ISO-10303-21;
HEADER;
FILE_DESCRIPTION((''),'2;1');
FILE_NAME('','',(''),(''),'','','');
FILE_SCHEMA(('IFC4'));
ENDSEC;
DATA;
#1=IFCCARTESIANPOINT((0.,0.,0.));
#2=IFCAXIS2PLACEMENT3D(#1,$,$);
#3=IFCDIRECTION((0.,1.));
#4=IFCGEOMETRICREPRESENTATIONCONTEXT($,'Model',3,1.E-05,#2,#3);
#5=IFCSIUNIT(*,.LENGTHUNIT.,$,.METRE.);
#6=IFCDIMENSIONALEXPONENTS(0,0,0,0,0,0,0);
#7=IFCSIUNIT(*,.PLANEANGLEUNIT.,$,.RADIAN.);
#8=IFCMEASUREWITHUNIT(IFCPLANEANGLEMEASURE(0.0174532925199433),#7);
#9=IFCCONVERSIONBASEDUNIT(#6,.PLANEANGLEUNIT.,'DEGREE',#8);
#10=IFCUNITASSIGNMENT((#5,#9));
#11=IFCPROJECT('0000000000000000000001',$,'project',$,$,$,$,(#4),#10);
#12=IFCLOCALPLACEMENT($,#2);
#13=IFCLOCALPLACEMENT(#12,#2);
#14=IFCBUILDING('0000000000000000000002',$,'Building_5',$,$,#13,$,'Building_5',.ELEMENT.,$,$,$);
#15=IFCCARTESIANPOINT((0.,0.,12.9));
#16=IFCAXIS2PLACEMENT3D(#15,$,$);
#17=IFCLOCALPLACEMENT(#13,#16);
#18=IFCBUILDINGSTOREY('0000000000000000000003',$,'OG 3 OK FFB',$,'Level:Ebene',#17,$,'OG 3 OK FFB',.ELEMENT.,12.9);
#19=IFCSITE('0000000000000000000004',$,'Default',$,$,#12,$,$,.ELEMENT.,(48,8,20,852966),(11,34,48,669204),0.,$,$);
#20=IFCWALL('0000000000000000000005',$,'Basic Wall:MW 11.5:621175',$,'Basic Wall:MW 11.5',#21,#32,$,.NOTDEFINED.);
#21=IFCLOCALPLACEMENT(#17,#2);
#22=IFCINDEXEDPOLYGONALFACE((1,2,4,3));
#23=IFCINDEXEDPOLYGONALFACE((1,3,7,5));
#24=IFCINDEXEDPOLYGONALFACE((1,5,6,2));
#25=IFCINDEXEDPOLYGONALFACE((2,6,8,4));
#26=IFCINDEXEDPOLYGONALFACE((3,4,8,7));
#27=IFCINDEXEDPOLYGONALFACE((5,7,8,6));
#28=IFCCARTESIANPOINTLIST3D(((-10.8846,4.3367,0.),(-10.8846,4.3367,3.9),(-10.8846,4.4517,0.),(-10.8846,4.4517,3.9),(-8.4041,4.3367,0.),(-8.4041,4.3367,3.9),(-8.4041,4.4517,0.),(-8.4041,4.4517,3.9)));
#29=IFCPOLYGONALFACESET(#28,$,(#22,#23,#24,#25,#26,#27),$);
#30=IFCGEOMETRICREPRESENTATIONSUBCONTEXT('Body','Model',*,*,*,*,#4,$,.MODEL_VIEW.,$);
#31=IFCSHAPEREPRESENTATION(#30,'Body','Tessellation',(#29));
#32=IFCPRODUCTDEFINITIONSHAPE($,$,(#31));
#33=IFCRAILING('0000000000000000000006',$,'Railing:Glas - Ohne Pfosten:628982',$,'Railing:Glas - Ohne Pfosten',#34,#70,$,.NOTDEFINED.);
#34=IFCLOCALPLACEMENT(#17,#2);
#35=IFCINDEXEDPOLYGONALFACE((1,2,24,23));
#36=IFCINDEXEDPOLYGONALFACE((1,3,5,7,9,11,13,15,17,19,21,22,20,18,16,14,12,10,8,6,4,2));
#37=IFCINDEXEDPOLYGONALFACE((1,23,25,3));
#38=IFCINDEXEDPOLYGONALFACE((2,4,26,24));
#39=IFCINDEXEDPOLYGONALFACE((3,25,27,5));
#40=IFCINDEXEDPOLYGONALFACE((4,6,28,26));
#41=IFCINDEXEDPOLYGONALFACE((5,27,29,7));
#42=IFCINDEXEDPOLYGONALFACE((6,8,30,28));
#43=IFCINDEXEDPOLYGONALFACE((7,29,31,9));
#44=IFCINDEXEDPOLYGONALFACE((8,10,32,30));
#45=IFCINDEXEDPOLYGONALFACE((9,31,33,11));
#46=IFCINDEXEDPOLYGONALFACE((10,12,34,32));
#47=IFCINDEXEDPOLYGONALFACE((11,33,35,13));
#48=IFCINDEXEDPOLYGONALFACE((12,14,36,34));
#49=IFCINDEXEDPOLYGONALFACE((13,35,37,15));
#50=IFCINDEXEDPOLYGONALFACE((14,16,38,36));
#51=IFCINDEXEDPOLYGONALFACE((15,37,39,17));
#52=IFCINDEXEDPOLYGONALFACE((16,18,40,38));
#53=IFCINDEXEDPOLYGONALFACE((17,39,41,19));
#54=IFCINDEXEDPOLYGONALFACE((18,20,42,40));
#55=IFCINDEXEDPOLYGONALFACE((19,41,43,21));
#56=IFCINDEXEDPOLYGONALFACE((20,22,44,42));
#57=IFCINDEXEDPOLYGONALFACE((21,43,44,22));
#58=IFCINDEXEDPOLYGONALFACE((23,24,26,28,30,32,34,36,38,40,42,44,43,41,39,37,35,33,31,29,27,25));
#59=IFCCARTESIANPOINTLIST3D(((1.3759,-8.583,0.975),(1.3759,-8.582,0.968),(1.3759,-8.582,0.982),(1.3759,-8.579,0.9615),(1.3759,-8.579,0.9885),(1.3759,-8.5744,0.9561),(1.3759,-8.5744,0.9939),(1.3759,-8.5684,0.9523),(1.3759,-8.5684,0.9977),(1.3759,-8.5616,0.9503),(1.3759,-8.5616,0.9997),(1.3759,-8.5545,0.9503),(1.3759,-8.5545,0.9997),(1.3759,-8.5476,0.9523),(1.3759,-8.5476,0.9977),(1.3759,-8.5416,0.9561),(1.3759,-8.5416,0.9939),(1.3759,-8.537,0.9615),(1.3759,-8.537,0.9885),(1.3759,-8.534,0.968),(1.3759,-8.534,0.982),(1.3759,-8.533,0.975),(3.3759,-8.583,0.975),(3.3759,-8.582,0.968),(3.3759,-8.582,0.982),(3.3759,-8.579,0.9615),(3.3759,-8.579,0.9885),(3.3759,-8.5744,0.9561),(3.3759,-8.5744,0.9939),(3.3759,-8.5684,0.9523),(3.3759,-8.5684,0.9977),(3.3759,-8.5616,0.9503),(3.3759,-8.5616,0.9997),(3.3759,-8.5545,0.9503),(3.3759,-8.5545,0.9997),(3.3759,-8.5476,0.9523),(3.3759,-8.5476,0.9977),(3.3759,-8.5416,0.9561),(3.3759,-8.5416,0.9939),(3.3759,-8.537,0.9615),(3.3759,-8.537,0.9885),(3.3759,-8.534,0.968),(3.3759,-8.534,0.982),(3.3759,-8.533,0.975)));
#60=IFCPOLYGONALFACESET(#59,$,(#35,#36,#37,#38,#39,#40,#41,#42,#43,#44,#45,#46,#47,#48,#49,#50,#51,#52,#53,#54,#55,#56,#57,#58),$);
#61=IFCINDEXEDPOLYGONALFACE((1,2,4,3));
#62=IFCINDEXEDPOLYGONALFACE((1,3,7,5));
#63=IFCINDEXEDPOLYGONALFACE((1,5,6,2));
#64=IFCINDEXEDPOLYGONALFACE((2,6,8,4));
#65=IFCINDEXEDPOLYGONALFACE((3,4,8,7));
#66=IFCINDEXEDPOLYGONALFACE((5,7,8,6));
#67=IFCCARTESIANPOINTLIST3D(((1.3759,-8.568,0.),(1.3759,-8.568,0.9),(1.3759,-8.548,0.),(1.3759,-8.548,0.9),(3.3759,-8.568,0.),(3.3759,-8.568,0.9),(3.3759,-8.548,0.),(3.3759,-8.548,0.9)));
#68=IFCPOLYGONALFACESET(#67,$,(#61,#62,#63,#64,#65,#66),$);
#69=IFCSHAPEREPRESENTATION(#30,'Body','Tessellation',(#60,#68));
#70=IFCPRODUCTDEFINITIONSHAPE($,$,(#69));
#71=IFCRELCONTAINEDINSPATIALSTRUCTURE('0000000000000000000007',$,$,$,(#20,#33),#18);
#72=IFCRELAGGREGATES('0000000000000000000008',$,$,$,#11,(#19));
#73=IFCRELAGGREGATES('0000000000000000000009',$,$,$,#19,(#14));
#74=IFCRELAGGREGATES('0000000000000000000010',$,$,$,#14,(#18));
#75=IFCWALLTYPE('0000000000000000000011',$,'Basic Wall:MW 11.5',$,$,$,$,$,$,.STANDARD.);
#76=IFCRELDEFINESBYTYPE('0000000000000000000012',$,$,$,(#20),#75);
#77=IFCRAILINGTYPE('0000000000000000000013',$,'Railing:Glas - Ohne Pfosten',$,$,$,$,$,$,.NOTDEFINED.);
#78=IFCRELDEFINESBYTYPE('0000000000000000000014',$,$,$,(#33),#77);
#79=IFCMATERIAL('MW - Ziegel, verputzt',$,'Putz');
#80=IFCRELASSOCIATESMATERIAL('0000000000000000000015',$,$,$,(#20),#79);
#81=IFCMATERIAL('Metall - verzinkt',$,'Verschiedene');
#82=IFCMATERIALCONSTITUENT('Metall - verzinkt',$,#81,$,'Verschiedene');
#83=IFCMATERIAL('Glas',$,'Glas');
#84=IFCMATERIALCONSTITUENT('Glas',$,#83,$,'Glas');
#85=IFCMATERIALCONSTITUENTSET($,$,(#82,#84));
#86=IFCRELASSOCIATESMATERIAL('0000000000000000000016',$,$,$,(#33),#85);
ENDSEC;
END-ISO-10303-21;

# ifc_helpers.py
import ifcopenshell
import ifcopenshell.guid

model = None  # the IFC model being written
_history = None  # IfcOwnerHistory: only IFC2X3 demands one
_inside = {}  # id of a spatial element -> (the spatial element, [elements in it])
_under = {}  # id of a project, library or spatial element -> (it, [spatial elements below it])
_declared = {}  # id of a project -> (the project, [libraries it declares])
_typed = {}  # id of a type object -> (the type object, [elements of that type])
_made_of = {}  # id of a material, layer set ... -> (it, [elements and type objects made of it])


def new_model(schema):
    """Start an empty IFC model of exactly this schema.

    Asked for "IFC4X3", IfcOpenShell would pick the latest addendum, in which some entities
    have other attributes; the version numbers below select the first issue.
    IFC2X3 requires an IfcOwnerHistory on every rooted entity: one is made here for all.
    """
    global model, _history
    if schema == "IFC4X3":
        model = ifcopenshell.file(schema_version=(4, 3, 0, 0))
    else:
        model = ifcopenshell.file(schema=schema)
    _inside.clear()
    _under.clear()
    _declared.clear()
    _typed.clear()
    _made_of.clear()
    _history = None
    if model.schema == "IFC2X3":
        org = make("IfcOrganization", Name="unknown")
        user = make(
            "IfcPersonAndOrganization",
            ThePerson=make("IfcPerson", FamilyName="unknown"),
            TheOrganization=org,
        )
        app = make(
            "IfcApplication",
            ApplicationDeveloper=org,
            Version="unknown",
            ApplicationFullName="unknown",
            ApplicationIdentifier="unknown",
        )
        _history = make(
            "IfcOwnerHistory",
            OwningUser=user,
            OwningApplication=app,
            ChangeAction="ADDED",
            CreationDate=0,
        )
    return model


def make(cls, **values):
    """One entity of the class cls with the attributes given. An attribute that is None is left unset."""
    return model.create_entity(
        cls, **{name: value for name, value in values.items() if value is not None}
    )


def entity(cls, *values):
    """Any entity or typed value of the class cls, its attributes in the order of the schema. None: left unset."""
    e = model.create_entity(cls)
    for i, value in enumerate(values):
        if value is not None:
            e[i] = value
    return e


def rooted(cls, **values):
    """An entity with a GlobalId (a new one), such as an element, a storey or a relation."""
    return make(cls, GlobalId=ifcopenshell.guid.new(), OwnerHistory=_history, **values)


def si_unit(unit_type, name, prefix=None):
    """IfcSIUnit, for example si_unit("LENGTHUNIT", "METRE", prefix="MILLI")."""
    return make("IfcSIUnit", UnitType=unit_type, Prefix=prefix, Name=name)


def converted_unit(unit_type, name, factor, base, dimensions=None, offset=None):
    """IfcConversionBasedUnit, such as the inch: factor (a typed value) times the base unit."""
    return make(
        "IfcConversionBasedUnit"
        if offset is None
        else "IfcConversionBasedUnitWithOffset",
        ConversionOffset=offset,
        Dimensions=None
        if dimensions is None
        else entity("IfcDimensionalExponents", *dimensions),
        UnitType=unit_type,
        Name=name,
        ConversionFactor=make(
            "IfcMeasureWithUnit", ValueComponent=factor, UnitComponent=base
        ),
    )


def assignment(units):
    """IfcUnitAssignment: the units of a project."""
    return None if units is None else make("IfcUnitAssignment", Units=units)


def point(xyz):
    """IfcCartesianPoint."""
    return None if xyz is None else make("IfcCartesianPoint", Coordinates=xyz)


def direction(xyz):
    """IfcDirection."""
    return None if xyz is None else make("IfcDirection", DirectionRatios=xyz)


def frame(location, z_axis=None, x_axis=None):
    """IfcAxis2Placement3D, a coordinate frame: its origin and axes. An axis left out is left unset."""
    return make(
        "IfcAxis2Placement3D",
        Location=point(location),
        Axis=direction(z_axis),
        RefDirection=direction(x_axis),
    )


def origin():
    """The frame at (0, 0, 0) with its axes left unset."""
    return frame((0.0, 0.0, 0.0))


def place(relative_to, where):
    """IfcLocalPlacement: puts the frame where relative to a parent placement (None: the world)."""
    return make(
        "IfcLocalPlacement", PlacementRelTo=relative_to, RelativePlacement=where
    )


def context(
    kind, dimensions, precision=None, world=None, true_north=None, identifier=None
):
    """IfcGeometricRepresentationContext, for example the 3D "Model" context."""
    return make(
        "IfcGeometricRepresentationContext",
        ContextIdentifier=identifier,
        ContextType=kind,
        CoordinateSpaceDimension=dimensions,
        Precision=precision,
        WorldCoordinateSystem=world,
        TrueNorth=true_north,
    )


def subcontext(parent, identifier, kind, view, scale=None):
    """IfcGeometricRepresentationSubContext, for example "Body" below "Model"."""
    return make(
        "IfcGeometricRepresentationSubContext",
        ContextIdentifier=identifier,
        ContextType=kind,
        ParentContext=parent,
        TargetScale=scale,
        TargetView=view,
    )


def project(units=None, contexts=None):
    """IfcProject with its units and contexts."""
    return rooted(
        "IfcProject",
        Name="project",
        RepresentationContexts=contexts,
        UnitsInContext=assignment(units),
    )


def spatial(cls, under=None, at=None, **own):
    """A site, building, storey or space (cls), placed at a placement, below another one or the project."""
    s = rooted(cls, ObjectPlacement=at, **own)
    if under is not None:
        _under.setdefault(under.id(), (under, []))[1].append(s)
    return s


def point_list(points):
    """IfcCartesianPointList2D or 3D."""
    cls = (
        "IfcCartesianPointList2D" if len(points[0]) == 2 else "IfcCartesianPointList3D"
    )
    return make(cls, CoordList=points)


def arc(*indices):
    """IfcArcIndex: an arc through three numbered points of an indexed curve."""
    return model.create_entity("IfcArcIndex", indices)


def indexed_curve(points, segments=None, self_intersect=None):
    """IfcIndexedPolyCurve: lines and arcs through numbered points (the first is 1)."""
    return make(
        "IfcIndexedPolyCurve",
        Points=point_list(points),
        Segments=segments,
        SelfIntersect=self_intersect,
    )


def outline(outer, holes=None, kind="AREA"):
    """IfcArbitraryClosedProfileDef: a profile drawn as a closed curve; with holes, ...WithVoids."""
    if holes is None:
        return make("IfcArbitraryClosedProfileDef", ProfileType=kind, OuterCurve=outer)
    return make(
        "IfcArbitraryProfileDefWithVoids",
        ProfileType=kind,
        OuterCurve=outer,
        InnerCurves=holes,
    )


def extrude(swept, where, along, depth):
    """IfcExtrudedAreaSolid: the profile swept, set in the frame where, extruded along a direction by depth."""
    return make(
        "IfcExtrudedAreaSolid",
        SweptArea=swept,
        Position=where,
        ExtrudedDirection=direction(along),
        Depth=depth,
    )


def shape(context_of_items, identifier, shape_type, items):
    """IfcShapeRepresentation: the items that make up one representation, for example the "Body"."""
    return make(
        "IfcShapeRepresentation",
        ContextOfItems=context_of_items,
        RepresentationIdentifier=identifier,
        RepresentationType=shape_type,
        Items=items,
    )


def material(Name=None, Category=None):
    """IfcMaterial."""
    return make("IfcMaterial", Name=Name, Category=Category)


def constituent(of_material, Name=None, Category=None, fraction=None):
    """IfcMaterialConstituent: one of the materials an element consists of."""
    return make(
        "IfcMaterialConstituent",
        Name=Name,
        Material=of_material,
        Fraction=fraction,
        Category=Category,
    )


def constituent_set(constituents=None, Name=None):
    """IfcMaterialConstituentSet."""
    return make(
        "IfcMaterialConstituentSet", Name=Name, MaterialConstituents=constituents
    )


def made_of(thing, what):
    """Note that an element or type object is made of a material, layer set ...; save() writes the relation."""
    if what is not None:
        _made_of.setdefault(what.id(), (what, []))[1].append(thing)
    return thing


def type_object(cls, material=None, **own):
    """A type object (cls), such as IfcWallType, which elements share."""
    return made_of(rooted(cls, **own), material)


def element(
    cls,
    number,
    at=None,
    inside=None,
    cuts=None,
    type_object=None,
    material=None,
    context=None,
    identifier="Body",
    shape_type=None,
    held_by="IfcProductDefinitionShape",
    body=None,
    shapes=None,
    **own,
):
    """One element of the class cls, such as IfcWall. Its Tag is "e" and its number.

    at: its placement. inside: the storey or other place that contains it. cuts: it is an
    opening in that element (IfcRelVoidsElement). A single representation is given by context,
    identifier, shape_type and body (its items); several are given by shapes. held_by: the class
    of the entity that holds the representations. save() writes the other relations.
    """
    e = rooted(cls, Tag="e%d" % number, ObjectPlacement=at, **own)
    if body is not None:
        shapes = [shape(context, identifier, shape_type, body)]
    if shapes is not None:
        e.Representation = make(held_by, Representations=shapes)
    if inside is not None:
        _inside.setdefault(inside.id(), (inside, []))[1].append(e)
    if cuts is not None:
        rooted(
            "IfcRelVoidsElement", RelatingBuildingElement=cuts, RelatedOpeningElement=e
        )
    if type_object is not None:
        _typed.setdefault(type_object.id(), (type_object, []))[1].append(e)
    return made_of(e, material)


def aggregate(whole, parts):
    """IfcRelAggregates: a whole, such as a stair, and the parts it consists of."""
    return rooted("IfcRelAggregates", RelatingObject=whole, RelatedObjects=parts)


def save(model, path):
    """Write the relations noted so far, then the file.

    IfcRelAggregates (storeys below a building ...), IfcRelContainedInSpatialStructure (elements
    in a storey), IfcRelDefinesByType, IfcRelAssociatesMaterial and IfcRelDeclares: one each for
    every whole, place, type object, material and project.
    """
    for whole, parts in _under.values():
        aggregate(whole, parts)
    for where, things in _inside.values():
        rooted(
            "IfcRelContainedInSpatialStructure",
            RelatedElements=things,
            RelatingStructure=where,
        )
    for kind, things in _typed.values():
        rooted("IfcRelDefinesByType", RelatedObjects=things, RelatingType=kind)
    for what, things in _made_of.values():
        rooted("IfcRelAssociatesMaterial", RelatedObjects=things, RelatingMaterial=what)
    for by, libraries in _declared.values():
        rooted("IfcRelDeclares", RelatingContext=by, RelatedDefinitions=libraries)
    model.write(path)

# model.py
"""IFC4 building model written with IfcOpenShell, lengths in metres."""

from ifc_helpers import new_model, entity, si_unit, converted_unit, direction, frame, origin, place, context, subcontext, project, spatial, arc, indexed_curve, outline, extrude, material, constituent, constituent_set, type_object, element, save


model = new_model("IFC4")

# Units and contexts
model_context = context("Model", 3, precision=1e-05, world=origin(), true_north=direction((0.0, 1.0)))
body_context = subcontext(model_context, "Body", "Model", "MODEL_VIEW")
ifc_project = project(units=[si_unit("LENGTHUNIT", "METRE"), converted_unit("PLANEANGLEUNIT", "DEGREE", entity("IfcPlaneAngleMeasure", 0.0174532925199433), si_unit("PLANEANGLEUNIT", "RADIAN"), dimensions=[0, 0, 0, 0, 0, 0, 0])], contexts=[model_context])

# Site, building, storey
site_placement = place(None, origin())
site = spatial("IfcSite", under=ifc_project, at=site_placement, Name="Default", CompositionType="ELEMENT", RefLatitude=(48, 8, 20, 852966), RefLongitude=(11, 34, 48, 669204), RefElevation=0.0)
building_placement = place(site_placement, origin())
building = spatial("IfcBuilding", under=site, at=building_placement, Name="Building_5", LongName="Building_5", CompositionType="ELEMENT")
storey_placement = place(building_placement, frame((0.0, 0.0, 12.9)))
storey = spatial("IfcBuildingStorey", under=building, at=storey_placement, Name="OG 3 OK FFB", ObjectType="Level:Ebene", LongName="OG 3 OK FFB", CompositionType="ELEMENT", Elevation=12.9)

# Shared definitions
ifc_material_1 = material(Name="Glas", Category="Glas")

# Wall
ifc_material_2 = material(Name="MW - Ziegel, verputzt", Category="Putz")
wall_type_1 = type_object("IfcWallType", Name="Basic Wall:MW 11.5", PredefinedType="STANDARD")
for number, where, z_axis, x_axis, name in (
    (1, (-8.4041, 4.3942, 0.0), (0.0, 0.0, 1.0), (-1.0, 0.0, 0.0), "Basic Wall:MW 11.5:621175"),
):
    element("IfcWall", number, at=place(storey_placement, frame(where, z_axis=z_axis, x_axis=x_axis)), inside=storey, type_object=wall_type_1, material=ifc_material_2, Name=name, ObjectType="Basic Wall:MW 11.5", PredefinedType="NOTDEFINED", context=body_context, shape_type="SweptSolid", body=[
        extrude(outline(indexed_curve([(2.4805, 0.0575), (0.0, 0.0575), (0.0, -0.0575), (2.4805, -0.0575), (2.4805, 0.0575)], self_intersect=False)), origin(), (0.0, 0.0, 1.0), 3.9),
    ])

# Railing
ifc_material_3 = material(Name="Metall - verzinkt", Category="Verschiedene")
ifc_constituent_1 = constituent(ifc_material_3, Name="Metall - verzinkt", Category="Verschiedene")
ifc_constituent_2 = constituent(ifc_material_1, Name="Glas", Category="Glas")
ifc_constituent_set_1 = constituent_set(constituents=[ifc_constituent_1, ifc_constituent_2])
railing_type = type_object("IfcRailingType", Name="Railing:Glas - Ohne Pfosten", PredefinedType="NOTDEFINED")
railing_placement = place(storey_placement, origin())
element("IfcRailing", 2, at=railing_placement, inside=storey, type_object=railing_type, material=ifc_constituent_set_1, Name="Railing:Glas - Ohne Pfosten:628982", ObjectType="Railing:Glas - Ohne Pfosten", PredefinedType="NOTDEFINED", context=body_context, shape_type="SweptSolid", body=[
    extrude(outline(indexed_curve([(-0.025, 0.0), (0.0, -0.025), (0.025, 0.0), (0.0, 0.025)], segments=[arc(1, 2, 3), arc(3, 4, 1)], self_intersect=False)), frame((1.3759, -8.558, 0.975), z_axis=(1.0, 0.0, 0.0), x_axis=(0.0, -1.0, 0.0)), (0.0, 0.0, 1.0), 2.0),
    extrude(outline(indexed_curve([(-1.0, -0.01), (1.0, -0.01), (1.0, 0.01), (-1.0, 0.01), (-1.0, -0.01)], self_intersect=False)), frame((2.3759, -8.558, 0.0)), (0.0, 0.0, 1.0), 0.9),
])

save(model, "model.ifc")
